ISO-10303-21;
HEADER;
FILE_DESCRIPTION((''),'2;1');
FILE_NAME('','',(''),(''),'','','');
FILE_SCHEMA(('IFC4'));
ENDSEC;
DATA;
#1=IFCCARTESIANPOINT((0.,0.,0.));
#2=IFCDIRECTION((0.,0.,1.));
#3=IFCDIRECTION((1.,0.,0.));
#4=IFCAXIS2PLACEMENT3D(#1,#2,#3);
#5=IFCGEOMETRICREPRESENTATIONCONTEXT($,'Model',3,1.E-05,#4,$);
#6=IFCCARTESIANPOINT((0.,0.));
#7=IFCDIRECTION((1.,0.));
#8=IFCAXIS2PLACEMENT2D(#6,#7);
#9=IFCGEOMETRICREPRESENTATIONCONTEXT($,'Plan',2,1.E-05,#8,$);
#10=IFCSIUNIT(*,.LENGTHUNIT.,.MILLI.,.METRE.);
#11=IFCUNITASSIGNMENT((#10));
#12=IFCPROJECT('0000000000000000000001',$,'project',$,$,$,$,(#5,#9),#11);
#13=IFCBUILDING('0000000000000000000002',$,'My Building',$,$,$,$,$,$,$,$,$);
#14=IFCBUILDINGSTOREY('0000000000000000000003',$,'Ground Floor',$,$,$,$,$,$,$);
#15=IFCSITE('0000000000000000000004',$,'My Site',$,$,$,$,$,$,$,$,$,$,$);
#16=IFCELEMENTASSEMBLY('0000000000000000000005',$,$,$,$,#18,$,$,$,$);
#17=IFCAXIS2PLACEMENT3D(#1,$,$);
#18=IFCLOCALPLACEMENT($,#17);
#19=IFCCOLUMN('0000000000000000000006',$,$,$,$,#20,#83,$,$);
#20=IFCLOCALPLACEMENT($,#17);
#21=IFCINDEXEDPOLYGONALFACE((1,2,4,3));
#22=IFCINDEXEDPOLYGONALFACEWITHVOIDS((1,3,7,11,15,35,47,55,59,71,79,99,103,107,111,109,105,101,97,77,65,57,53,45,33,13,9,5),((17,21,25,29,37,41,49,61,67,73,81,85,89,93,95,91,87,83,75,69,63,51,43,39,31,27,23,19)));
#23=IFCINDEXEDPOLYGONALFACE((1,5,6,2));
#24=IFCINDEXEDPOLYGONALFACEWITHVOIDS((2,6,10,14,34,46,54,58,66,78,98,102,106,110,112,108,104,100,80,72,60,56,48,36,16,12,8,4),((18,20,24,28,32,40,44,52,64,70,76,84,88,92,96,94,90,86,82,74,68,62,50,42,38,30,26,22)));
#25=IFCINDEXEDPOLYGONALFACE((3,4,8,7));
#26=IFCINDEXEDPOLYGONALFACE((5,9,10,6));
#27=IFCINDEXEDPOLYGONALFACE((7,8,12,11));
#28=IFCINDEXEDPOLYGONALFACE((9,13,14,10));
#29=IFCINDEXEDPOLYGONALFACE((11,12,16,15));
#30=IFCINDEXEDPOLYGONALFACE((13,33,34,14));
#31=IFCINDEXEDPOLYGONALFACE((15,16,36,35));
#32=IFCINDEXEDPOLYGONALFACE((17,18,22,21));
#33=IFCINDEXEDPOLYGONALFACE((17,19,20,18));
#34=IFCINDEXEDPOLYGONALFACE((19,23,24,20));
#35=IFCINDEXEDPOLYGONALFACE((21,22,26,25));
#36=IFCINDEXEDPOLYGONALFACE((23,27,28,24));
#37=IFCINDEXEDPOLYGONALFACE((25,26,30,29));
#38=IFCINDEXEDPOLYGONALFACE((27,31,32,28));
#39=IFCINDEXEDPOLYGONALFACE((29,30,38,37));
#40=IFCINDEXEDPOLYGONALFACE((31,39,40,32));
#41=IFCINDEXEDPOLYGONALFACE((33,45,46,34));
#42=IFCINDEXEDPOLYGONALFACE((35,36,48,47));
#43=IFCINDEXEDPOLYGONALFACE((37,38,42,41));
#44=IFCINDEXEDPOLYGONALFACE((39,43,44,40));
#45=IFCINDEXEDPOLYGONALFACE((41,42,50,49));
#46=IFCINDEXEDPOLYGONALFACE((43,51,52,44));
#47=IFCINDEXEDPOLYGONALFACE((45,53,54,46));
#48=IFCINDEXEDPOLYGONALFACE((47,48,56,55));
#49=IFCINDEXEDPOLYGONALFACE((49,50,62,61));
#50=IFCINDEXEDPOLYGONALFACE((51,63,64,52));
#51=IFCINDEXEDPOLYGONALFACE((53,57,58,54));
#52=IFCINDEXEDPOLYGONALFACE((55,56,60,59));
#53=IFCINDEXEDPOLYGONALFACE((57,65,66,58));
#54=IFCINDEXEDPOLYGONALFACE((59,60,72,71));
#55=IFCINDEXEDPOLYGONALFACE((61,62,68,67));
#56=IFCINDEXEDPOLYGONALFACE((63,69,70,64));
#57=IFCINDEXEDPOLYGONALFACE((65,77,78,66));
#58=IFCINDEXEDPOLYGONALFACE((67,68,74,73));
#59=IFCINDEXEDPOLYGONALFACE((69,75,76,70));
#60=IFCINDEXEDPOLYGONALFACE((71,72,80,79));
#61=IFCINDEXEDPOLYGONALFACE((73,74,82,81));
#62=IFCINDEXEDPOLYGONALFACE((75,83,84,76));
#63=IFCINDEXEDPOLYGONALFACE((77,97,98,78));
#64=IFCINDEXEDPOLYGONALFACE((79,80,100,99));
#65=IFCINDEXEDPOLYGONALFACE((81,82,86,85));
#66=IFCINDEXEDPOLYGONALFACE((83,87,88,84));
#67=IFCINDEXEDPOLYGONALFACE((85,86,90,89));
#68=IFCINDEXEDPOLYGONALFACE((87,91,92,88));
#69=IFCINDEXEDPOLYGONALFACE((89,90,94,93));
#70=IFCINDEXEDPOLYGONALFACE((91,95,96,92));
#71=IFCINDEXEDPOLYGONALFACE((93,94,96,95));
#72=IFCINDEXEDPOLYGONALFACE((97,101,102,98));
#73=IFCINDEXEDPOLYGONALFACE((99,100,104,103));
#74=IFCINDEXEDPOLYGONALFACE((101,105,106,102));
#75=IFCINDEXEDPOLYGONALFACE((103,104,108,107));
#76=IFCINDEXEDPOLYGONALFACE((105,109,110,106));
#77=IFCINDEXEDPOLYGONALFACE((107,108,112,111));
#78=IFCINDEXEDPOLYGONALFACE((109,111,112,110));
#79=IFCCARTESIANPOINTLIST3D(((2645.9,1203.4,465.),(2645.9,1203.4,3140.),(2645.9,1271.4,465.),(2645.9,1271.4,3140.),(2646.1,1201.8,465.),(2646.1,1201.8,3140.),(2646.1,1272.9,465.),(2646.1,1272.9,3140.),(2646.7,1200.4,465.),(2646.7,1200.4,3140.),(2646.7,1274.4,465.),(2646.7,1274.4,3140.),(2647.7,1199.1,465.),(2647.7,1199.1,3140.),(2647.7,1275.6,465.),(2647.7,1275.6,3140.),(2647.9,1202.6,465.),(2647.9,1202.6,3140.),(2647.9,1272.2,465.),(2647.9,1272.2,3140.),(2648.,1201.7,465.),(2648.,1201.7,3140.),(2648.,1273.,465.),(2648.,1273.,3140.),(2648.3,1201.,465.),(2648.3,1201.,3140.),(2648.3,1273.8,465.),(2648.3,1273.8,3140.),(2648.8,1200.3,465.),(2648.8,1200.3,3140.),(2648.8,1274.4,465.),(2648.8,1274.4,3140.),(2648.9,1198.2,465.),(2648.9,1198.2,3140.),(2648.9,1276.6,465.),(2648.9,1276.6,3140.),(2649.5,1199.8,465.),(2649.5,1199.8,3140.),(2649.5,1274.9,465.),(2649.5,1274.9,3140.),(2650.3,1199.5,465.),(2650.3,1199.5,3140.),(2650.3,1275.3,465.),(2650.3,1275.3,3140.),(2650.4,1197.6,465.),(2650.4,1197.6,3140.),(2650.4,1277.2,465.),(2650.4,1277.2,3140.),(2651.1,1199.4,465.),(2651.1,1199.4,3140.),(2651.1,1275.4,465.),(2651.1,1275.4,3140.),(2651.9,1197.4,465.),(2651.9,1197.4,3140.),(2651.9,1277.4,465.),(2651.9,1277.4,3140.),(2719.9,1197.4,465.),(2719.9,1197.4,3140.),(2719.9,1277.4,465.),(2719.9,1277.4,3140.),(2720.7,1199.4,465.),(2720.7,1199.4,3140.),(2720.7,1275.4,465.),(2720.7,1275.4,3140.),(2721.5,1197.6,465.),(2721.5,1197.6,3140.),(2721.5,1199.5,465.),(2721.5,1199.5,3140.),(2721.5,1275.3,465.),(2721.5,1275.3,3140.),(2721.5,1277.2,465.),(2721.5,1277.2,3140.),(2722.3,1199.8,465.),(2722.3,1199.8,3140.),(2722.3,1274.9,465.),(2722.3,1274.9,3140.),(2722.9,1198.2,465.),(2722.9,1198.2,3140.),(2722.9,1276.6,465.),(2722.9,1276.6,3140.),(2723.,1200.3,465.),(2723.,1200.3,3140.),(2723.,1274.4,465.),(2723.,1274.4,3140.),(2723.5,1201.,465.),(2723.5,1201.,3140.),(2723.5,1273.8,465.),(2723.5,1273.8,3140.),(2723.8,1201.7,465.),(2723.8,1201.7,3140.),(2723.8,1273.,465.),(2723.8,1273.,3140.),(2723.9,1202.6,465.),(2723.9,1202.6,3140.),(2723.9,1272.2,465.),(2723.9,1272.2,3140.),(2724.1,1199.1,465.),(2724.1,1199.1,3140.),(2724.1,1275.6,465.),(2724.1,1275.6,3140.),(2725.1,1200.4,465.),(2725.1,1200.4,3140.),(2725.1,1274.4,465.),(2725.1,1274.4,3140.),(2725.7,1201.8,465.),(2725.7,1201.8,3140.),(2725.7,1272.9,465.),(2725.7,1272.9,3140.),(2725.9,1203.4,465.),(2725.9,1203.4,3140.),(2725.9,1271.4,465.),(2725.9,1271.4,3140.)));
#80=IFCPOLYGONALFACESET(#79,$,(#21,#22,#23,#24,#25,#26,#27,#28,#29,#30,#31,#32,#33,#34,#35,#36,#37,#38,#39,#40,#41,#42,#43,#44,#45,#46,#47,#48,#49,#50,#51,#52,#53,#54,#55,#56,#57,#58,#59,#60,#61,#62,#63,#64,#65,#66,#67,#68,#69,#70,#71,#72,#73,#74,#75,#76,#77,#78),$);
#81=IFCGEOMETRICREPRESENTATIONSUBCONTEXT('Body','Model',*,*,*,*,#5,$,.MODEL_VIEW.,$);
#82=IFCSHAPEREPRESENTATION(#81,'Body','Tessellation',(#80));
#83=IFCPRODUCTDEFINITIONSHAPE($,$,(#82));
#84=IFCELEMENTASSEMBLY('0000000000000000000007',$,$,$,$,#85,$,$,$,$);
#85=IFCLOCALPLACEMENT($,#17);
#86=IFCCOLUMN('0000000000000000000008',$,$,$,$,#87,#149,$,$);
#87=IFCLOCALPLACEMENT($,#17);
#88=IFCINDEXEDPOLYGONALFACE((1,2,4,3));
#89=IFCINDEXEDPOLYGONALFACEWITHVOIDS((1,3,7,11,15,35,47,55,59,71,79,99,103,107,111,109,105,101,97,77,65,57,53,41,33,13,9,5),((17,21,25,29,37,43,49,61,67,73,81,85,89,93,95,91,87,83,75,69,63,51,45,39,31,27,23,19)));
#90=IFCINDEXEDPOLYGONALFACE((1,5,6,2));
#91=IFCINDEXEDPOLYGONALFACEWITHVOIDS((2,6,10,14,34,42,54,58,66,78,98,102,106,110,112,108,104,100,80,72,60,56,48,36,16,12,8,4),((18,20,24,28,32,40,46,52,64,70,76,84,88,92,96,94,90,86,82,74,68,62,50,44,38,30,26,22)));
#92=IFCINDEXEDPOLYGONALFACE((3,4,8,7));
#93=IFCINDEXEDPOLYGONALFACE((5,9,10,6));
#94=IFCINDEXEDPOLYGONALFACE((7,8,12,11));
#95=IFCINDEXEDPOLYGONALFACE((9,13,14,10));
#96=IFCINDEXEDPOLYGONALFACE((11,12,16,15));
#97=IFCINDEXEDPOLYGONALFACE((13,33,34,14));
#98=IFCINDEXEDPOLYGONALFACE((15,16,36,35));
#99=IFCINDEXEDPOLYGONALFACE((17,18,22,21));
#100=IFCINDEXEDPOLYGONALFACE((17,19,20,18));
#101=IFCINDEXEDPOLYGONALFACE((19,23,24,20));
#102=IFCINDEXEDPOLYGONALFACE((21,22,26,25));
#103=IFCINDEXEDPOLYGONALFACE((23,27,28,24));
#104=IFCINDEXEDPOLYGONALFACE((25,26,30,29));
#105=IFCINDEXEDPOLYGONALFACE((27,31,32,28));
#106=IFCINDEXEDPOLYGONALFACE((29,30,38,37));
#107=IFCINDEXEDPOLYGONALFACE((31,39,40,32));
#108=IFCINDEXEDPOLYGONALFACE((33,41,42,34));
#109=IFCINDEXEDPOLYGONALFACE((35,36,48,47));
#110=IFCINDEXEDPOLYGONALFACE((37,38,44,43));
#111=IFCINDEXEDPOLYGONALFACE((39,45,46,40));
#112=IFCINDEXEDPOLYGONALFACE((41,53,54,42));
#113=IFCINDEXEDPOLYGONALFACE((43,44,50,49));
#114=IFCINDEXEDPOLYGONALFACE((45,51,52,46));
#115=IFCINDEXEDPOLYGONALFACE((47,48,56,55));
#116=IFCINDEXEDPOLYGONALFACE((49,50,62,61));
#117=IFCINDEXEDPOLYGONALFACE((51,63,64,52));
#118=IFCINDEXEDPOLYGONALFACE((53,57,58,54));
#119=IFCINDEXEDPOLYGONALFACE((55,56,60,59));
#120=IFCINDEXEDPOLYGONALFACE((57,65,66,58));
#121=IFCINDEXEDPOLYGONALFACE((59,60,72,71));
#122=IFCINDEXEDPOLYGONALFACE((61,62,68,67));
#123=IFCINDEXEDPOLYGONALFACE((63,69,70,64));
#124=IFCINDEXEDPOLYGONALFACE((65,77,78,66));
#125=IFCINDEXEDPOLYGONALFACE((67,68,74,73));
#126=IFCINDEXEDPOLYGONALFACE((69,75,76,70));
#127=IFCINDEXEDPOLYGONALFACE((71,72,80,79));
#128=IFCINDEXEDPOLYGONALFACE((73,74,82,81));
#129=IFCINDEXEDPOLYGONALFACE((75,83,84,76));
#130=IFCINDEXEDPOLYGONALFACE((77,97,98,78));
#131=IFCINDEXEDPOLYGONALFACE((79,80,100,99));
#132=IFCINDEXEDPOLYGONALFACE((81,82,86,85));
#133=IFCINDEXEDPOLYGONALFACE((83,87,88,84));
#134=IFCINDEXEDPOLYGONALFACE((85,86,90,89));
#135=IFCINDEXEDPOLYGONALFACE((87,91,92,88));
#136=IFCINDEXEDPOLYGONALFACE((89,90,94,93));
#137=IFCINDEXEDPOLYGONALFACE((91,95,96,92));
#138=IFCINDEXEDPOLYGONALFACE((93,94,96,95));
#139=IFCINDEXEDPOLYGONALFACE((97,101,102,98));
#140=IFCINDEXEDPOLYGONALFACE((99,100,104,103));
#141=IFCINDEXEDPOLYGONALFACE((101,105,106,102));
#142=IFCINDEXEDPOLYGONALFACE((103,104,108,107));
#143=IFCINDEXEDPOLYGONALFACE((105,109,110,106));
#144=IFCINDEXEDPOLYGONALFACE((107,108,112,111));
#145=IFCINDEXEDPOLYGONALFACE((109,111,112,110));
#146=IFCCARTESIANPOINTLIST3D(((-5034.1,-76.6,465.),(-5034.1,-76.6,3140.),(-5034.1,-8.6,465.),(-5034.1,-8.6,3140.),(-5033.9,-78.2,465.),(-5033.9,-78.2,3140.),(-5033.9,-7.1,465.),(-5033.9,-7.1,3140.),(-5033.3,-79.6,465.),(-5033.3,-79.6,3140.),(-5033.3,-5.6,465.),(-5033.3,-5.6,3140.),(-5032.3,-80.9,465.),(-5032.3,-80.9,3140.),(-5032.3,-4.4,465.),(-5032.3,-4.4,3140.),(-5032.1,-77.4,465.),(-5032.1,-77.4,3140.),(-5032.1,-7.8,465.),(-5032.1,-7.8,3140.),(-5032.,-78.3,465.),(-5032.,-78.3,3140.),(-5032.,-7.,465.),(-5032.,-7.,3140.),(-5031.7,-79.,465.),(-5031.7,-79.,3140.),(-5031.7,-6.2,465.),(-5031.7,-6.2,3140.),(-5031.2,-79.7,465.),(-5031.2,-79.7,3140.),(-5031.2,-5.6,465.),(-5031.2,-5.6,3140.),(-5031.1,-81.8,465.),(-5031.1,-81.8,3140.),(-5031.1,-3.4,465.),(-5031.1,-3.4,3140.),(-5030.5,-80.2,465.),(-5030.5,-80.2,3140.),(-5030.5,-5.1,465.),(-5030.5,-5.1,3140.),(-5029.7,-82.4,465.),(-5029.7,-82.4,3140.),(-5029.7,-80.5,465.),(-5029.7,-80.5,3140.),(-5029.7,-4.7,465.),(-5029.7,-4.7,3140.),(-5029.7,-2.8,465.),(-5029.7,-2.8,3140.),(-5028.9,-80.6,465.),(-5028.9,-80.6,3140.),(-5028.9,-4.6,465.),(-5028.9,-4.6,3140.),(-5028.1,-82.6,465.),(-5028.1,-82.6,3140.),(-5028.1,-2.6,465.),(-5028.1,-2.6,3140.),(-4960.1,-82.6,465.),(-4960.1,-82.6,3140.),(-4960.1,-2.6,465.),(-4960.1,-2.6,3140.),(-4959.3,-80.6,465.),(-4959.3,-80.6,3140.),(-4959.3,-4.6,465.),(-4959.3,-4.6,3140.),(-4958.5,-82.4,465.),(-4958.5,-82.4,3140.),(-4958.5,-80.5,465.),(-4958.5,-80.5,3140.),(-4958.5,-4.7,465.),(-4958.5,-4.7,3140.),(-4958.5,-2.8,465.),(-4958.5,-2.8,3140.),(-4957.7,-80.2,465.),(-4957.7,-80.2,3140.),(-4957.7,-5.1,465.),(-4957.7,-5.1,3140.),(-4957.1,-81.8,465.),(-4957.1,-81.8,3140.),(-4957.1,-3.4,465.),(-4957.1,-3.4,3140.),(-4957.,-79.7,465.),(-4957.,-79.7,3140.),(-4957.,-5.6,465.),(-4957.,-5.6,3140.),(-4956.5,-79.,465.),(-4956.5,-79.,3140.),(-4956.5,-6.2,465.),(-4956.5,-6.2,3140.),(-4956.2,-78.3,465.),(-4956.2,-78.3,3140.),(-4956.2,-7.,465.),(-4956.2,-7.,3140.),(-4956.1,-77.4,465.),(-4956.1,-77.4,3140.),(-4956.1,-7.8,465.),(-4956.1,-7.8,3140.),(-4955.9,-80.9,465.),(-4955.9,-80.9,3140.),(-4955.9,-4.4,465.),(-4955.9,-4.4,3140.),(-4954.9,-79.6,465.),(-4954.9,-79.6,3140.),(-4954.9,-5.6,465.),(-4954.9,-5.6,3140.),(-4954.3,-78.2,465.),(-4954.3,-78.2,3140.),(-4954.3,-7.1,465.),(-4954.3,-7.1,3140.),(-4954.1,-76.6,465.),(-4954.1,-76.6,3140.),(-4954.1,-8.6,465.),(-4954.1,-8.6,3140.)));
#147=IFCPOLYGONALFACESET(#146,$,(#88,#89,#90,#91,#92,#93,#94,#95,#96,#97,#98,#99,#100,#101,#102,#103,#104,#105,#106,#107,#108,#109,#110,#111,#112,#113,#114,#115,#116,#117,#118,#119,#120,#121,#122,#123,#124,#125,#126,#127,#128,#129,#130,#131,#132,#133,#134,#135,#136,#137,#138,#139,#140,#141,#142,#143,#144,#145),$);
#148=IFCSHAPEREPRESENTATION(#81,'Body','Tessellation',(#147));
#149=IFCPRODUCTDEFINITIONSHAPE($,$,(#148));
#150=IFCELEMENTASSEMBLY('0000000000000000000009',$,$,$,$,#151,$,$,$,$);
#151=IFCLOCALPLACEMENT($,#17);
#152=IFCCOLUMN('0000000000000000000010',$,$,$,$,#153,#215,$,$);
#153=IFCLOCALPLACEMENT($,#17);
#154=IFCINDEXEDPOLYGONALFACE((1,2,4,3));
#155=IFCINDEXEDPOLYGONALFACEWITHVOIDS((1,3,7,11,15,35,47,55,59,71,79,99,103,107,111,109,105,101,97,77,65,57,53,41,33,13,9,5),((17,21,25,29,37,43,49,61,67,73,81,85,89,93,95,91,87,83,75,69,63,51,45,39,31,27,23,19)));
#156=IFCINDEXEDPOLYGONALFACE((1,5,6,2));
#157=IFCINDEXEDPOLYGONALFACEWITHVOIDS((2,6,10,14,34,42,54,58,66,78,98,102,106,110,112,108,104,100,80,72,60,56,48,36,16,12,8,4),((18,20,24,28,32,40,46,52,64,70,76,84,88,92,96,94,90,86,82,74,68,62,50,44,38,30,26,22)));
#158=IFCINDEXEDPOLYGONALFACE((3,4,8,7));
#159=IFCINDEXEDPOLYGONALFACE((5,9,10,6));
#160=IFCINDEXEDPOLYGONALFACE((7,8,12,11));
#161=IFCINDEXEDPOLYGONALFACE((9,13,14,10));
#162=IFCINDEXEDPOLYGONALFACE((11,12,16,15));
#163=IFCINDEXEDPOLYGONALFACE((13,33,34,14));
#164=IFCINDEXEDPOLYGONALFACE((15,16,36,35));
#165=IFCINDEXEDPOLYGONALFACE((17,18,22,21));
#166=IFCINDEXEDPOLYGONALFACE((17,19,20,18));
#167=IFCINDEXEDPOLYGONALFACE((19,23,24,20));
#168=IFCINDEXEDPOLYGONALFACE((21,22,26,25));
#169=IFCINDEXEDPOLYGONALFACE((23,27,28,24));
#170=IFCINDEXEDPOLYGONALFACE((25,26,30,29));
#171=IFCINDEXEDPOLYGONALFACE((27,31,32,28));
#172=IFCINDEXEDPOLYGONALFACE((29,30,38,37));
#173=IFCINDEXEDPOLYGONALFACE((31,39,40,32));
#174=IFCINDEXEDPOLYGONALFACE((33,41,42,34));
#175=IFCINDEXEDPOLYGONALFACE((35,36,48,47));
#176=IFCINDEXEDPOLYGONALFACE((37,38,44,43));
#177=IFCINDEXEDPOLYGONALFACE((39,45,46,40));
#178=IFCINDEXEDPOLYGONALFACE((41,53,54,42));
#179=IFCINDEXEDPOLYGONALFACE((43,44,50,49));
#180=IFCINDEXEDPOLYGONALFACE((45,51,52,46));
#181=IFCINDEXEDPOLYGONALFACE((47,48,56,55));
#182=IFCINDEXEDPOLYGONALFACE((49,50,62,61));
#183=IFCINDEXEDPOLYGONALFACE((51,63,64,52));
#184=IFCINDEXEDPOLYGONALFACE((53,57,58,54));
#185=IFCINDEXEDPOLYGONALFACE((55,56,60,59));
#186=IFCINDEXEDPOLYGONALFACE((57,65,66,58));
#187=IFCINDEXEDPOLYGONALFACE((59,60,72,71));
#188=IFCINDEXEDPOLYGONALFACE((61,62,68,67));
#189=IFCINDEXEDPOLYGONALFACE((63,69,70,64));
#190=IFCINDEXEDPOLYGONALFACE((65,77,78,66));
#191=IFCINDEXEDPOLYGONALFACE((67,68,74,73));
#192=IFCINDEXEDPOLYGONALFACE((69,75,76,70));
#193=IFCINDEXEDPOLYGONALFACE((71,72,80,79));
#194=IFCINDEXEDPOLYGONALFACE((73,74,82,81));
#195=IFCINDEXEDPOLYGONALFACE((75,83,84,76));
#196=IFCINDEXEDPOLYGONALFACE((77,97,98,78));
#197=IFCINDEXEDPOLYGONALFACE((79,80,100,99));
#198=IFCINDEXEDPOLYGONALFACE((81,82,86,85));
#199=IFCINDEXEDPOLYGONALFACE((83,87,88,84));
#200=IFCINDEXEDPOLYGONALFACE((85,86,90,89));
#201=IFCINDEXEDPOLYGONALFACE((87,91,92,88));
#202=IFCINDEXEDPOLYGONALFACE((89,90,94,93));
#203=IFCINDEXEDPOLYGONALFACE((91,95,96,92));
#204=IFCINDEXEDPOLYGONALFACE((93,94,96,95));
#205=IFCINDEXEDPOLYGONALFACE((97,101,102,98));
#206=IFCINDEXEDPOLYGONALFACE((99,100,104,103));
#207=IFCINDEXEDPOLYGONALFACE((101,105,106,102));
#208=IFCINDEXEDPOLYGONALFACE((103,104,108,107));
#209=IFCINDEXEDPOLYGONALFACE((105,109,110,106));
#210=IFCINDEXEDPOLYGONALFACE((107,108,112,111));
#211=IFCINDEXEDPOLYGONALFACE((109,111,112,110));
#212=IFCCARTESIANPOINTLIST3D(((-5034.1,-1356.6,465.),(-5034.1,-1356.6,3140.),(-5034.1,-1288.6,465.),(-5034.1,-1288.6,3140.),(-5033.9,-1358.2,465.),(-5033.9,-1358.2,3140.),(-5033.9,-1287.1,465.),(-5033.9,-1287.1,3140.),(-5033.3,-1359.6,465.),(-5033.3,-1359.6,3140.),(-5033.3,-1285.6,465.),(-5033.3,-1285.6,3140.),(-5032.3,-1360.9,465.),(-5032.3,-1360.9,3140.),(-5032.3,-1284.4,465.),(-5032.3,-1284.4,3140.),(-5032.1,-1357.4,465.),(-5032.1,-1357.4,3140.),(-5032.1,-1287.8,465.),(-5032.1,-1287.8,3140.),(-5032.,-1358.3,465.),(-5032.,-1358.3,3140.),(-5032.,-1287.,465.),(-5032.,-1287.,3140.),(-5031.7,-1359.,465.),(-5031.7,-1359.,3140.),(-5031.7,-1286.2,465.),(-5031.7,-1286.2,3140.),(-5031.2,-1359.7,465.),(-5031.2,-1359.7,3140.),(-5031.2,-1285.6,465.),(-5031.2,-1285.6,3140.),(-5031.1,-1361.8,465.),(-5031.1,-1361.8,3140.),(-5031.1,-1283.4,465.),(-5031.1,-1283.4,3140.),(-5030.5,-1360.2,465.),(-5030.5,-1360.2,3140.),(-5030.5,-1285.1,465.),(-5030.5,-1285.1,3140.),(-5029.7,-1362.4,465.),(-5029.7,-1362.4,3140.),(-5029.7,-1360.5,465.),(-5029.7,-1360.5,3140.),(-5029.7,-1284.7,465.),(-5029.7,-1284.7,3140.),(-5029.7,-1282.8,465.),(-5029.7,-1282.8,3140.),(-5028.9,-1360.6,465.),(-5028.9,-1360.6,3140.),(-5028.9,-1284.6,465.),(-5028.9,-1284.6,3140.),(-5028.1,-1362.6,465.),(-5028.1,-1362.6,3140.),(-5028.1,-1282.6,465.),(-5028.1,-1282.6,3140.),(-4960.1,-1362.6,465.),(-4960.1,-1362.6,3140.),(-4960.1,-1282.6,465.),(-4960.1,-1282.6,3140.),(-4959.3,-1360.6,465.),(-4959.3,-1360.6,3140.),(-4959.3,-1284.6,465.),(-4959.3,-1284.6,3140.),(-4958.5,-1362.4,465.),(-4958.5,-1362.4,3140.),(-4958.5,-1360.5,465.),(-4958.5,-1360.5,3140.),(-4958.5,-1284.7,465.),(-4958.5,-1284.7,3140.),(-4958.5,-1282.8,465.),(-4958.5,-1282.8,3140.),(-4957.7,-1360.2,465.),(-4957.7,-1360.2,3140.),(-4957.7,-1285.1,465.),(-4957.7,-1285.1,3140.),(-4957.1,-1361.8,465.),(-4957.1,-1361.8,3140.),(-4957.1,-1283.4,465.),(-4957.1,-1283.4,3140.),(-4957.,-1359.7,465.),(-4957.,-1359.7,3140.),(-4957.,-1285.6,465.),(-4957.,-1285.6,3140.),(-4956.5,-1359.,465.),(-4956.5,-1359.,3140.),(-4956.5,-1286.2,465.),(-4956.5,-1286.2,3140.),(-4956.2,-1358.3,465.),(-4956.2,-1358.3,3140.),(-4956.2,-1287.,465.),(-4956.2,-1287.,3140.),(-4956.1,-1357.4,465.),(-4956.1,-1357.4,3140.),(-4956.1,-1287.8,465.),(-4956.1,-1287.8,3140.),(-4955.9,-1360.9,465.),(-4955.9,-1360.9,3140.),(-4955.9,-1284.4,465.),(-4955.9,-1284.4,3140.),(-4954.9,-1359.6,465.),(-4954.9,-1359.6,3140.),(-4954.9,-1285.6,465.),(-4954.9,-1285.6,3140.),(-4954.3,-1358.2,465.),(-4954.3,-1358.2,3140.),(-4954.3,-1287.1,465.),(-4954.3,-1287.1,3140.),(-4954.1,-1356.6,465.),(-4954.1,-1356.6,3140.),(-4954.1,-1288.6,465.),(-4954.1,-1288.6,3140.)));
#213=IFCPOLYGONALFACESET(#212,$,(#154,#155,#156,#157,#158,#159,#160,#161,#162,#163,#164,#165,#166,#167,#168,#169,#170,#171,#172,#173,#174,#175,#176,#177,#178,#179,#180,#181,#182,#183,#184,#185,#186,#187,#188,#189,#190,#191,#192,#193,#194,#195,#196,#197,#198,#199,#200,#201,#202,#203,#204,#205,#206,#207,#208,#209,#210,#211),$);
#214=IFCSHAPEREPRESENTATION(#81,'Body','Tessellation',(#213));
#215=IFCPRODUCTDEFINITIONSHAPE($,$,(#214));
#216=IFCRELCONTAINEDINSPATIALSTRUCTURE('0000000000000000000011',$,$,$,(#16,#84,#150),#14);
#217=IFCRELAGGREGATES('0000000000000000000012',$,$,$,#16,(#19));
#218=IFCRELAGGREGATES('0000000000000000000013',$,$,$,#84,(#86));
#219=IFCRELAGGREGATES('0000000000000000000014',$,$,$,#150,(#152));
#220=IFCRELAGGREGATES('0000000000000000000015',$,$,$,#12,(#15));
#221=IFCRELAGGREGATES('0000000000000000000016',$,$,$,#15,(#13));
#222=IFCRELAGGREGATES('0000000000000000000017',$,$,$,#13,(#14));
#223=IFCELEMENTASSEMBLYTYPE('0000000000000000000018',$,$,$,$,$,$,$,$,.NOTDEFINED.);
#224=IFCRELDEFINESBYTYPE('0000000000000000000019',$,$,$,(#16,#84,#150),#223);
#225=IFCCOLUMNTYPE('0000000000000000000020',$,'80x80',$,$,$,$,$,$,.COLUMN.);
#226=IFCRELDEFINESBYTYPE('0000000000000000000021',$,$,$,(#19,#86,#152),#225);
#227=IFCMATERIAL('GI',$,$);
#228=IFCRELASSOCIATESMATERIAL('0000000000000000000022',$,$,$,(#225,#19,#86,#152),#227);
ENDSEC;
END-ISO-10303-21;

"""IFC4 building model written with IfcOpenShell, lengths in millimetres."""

from ifc_helpers import new_model, si_unit, frame, origin_with_axes, origin_2d_with_axis, place, context, subcontext, project, spatial, hollow_rectangle, extrude, material, material_profile, profile_set, profile_usage, type_object, element, aggregate, save


model = new_model("IFC4")

# Units and contexts
model_context = context("Model", 3, precision=1e-05, world=origin_with_axes())
plan_context = context("Plan", 2, precision=1e-05, world=origin_2d_with_axis())
body_context = subcontext(model_context, "Body", "Model", "MODEL_VIEW")
ifc_project = project(units=[si_unit("LENGTHUNIT", "METRE", prefix="MILLI")], contexts=[model_context, plan_context])

# Site, building, storey
site = spatial("IfcSite", under=ifc_project, Name="My Site")
building = spatial("IfcBuilding", under=site, Name="My Building")
storey = spatial("IfcBuildingStorey", under=building, Name="Ground Floor")

# Element assemblies, columns
element_assembly_type_1 = type_object("IfcElementAssemblyType", PredefinedType="NOTDEFINED")
ifc_material_1 = material(Name="GI")
ifc_material_profile_1 = material_profile(ifc_material_1, hollow_rectangle(XDim=80.0, YDim=80.0, WallThickness=2.0, InnerFilletRadius=3.2, OuterFilletRadius=6.0))
ifc_profile_set_1 = profile_set([ifc_material_profile_1], Name="80x80 GI Rectangular Hollow")
column_type = type_object("IfcColumnType", Name="80x80", PredefinedType="COLUMN", material=ifc_profile_set_1)
assembly_1_placement = place(None, frame((2685.9, 1237.4, 465.0), z_axis=(0.0, 0.0, 1.0), x_axis=(1.0, 0.0, 0.0)))
assembly_1 = element("IfcElementAssembly", 1, at=assembly_1_placement, inside=storey, type_object=element_assembly_type_1)
ifc_profile_usage_1 = profile_usage(ifc_profile_set_1)
column_1_placement = place(assembly_1_placement, origin_with_axes())
column_1 = element("IfcColumn", 2, at=column_1_placement, type_object=column_type, material=ifc_profile_usage_1, context=body_context, shape_type="SweptSolid", body=[
    extrude(hollow_rectangle(XDim=80.0, YDim=80.0, WallThickness=2.0, InnerFilletRadius=3.2, OuterFilletRadius=6.0), origin_with_axes(), (0.0, 0.0, 1.0), 2675.0),
])
aggregate(assembly_1, [column_1])
assembly_2_placement = place(None, frame((-4994.1, -42.6, 465.0), z_axis=(0.0, 0.0, 1.0), x_axis=(1.0, 0.0, 0.0)))
assembly_2 = element("IfcElementAssembly", 3, at=assembly_2_placement, inside=storey, type_object=element_assembly_type_1)
ifc_profile_usage_2 = profile_usage(ifc_profile_set_1)
column_2_placement = place(assembly_2_placement, origin_with_axes())
column_2 = element("IfcColumn", 4, at=column_2_placement, type_object=column_type, material=ifc_profile_usage_2, context=body_context, shape_type="SweptSolid", body=[
    extrude(hollow_rectangle(XDim=80.0, YDim=80.0, WallThickness=2.0, InnerFilletRadius=3.2, OuterFilletRadius=6.0), origin_with_axes(), (0.0, 0.0, 1.0), 2675.0),
])
aggregate(assembly_2, [column_2])
assembly_3_placement = place(None, frame((-4994.1, -1322.6, 465.0), z_axis=(0.0, 0.0, 1.0), x_axis=(1.0, 0.0, 0.0)))
assembly_3 = element("IfcElementAssembly", 5, at=assembly_3_placement, inside=storey, type_object=element_assembly_type_1)
ifc_profile_usage_3 = profile_usage(ifc_profile_set_1)
column_3_placement = place(assembly_3_placement, origin_with_axes())
column_3 = element("IfcColumn", 6, at=column_3_placement, type_object=column_type, material=ifc_profile_usage_3, context=body_context, shape_type="SweptSolid", body=[
    extrude(hollow_rectangle(XDim=80.0, YDim=80.0, WallThickness=2.0, InnerFilletRadius=3.2, OuterFilletRadius=6.0), origin_with_axes(), (0.0, 0.0, 1.0), 2675.0),
])
aggregate(assembly_3, [column_3])

save(model, "model.ifc")
